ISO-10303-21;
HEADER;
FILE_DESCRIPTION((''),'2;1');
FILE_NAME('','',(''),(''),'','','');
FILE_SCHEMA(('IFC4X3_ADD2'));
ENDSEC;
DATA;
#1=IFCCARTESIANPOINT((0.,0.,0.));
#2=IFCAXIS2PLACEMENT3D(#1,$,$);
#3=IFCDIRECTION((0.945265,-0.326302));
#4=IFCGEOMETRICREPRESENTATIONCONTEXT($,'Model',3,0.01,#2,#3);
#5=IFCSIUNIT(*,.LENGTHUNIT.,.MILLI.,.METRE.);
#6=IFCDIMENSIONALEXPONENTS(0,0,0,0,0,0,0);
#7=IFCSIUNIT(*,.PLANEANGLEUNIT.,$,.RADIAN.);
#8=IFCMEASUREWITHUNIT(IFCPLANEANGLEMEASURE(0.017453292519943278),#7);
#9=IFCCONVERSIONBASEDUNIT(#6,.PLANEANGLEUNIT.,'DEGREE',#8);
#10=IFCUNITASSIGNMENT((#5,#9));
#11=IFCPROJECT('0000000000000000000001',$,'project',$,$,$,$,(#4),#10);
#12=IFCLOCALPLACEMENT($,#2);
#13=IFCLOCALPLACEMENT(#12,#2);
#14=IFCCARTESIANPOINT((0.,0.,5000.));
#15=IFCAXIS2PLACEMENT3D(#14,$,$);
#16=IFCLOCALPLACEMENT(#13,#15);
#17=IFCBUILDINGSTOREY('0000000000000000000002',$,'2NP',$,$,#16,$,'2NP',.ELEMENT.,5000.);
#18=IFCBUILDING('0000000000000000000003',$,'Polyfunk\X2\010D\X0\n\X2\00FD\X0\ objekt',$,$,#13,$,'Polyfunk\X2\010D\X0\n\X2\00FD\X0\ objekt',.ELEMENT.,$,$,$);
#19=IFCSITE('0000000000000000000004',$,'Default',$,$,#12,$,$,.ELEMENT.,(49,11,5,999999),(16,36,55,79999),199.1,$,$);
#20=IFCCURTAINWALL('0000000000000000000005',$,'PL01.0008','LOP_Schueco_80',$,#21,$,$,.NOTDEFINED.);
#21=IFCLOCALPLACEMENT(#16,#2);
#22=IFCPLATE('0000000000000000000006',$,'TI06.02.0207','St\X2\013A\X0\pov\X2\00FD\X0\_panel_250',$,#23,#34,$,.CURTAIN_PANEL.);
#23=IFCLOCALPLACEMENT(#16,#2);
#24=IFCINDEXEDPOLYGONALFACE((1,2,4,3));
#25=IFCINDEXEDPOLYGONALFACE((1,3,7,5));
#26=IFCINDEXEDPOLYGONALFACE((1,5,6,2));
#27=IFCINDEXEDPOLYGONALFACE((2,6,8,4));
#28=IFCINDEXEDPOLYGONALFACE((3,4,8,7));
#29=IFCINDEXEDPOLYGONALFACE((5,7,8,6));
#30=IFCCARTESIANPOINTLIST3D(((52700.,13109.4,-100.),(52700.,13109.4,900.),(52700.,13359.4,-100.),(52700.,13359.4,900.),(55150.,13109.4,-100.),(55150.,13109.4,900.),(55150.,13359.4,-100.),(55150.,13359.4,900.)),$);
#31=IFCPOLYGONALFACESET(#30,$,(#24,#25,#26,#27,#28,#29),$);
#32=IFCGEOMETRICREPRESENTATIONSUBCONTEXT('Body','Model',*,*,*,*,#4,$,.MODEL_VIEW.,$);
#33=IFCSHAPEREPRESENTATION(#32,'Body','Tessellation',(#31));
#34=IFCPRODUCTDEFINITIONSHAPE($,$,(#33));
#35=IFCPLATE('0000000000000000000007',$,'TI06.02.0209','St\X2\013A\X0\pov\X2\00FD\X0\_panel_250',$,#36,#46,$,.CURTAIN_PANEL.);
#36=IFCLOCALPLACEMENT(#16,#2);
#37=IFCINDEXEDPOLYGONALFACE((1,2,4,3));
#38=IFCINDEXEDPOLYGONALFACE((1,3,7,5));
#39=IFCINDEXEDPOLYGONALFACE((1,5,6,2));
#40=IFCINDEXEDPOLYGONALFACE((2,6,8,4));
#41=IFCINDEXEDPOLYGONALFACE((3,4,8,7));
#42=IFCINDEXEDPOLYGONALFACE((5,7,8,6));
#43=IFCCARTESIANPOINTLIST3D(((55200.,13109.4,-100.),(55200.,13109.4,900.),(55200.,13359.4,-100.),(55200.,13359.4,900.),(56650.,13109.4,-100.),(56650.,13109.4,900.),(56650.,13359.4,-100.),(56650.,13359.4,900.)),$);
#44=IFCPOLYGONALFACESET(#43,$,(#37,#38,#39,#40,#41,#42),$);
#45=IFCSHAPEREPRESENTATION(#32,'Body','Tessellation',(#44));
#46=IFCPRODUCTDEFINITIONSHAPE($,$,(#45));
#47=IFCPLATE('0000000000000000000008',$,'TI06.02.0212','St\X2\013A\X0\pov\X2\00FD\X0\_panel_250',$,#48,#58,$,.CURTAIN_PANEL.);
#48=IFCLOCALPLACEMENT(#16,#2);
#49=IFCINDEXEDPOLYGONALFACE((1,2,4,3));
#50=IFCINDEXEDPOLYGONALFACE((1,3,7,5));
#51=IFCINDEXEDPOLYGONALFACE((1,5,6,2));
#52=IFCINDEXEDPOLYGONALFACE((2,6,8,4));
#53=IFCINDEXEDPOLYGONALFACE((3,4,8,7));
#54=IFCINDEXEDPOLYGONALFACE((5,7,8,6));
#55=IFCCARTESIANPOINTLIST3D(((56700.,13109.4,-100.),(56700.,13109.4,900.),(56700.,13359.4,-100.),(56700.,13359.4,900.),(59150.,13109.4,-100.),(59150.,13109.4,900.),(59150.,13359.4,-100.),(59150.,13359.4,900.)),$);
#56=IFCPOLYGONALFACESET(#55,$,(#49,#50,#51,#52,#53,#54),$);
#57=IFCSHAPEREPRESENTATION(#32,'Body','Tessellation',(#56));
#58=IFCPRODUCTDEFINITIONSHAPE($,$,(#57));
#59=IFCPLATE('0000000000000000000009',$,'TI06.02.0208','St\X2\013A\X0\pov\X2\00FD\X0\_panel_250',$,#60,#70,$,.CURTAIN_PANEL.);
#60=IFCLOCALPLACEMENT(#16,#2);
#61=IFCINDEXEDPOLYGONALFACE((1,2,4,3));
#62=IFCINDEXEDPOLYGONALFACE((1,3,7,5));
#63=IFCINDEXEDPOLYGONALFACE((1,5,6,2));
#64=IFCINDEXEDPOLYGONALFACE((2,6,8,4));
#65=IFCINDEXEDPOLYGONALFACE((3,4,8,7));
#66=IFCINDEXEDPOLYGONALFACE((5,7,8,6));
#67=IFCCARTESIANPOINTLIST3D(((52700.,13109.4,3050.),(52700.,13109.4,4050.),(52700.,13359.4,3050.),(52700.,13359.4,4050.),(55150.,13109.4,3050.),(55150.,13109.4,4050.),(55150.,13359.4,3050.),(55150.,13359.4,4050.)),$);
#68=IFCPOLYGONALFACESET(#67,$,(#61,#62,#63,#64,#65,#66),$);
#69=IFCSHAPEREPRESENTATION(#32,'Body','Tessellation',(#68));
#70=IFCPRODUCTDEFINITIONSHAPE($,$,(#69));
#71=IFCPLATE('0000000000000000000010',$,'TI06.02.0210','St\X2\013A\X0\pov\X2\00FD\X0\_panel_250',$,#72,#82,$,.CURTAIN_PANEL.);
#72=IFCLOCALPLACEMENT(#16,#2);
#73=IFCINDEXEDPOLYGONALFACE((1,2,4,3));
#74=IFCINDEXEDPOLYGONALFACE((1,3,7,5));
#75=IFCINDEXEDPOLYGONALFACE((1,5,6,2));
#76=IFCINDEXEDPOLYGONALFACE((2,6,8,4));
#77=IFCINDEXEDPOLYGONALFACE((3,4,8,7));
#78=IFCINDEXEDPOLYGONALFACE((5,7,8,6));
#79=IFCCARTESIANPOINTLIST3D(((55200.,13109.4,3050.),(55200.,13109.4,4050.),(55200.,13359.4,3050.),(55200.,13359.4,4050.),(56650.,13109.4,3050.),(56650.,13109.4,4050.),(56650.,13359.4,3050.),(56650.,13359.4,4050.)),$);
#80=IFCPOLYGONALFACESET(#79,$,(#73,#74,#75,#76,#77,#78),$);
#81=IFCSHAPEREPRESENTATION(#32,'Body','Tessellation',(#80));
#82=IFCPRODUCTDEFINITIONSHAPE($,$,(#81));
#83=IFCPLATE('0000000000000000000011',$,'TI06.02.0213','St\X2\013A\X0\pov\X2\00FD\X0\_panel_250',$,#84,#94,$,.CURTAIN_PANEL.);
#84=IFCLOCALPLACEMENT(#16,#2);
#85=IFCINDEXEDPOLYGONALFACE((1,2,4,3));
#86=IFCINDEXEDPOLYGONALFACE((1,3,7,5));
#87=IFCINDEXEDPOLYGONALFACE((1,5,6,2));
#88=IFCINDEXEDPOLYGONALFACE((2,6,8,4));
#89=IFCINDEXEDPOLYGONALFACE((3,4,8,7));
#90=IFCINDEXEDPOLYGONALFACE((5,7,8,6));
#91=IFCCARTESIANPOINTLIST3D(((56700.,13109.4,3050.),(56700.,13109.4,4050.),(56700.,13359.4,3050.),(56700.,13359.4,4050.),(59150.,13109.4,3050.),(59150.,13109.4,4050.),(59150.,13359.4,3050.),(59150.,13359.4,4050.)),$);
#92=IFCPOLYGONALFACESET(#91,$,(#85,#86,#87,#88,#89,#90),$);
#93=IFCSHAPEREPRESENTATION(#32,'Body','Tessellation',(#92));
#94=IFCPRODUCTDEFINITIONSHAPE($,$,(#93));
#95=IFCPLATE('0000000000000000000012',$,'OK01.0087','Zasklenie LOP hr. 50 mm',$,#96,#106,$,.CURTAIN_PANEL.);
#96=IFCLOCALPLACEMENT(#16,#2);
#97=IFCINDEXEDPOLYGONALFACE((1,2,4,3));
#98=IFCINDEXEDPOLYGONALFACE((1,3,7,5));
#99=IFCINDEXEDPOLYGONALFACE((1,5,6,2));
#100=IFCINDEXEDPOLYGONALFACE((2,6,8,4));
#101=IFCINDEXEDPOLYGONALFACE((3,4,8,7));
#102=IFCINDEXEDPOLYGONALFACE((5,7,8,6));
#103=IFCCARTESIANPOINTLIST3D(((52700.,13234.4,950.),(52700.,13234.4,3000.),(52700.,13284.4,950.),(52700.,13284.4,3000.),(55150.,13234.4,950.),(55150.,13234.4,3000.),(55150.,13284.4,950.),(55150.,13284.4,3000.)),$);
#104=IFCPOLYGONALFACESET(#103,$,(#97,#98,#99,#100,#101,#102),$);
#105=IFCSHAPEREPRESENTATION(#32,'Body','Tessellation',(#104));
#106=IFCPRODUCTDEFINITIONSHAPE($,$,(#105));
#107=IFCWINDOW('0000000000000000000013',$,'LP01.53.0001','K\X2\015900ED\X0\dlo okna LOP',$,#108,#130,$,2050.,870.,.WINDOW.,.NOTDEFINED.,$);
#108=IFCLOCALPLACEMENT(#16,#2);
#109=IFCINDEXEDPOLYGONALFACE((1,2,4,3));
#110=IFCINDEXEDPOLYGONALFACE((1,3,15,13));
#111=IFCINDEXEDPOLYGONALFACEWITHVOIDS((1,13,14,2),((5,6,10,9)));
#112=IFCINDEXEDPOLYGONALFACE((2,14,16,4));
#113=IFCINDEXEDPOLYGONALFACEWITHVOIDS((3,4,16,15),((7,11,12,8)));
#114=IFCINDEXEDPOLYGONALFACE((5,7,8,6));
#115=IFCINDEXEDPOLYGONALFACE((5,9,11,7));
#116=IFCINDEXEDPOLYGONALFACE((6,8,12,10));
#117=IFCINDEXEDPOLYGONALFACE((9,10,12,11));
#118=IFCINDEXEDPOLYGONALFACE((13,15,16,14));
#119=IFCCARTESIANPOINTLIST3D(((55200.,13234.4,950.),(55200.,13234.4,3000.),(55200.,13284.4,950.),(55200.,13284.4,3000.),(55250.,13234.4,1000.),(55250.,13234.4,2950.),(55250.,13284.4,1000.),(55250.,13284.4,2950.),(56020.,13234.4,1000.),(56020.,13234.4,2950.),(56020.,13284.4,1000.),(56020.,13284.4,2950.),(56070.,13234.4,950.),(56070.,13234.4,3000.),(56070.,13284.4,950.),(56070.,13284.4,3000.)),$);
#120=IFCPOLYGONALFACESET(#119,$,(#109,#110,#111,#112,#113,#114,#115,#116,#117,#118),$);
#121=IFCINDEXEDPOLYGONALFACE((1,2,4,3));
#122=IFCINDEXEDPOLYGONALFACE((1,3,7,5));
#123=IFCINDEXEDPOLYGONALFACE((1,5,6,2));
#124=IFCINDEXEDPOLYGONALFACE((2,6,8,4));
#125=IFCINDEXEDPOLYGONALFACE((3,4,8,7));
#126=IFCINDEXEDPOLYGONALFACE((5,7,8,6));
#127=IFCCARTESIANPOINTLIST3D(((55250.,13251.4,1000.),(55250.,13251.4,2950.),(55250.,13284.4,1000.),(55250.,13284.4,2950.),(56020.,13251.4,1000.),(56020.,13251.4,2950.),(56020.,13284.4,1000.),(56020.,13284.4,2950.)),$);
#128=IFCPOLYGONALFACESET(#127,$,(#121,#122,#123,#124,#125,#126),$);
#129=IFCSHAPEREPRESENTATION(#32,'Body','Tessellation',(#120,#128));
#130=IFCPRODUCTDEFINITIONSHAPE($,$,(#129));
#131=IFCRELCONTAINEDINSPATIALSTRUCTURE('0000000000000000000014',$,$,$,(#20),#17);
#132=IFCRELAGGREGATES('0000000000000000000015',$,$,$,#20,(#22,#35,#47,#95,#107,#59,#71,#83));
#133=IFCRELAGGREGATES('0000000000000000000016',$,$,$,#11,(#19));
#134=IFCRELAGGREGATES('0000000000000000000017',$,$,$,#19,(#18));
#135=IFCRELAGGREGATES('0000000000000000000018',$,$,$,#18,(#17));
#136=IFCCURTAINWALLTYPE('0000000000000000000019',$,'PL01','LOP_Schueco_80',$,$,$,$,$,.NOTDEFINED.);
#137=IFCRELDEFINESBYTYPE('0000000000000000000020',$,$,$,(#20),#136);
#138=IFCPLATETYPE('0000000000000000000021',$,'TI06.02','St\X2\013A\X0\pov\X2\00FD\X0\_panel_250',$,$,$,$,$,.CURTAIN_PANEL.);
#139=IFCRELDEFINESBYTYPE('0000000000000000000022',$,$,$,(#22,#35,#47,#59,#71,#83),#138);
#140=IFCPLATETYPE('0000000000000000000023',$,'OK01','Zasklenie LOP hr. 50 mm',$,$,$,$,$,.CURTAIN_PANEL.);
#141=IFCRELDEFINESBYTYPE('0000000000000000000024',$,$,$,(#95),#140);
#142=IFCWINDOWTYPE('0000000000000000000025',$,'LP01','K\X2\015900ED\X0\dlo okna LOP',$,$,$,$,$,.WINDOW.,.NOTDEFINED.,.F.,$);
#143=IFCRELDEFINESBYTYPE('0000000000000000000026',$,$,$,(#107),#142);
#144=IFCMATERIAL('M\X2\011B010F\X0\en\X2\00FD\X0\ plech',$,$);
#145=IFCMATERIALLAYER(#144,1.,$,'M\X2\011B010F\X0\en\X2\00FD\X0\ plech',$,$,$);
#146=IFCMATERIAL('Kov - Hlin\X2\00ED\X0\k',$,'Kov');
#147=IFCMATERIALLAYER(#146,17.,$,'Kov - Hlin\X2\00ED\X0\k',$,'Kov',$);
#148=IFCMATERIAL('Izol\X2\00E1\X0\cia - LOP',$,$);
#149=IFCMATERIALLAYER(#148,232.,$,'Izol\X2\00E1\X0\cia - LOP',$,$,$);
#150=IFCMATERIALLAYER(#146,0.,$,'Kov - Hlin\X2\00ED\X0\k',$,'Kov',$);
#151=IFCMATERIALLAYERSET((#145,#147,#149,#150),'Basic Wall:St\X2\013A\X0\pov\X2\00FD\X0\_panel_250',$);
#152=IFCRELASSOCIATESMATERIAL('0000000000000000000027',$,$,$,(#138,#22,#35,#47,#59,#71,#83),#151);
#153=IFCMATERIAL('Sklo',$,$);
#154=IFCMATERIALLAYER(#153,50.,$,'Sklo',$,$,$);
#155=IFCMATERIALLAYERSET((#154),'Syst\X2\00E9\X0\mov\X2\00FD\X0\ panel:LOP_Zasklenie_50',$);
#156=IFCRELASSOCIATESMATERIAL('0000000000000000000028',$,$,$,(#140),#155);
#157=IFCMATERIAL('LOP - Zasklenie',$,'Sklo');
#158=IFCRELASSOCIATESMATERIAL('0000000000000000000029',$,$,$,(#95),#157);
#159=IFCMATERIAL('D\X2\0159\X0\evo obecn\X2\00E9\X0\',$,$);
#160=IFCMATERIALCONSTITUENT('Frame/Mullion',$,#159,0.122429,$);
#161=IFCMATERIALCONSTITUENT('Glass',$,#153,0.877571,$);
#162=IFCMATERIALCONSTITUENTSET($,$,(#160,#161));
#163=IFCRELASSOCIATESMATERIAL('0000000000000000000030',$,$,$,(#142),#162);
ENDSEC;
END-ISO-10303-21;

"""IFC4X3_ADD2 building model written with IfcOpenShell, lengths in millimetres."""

from ifc_helpers import new_model, entity, si_unit, converted_unit, direction, frame, frame_2d, origin, origin_2d_with_axis, place, context, subcontext, project, spatial, polyline, rectangle, outline, extrude, source, transform, mapped, material, layer, layer_set, layer_usage, constituent, constituent_set, type_object, type_shapes, element, aggregate, save


model = new_model("IFC4X3_ADD2")

# Units and contexts
model_context = context("Model", 3, precision=0.01, world=origin(), true_north=direction((0.945265, -0.326302)))
body_context = subcontext(model_context, "Body", "Model", "MODEL_VIEW")
ifc_project = project(units=[si_unit("LENGTHUNIT", "METRE", prefix="MILLI"), converted_unit("PLANEANGLEUNIT", "DEGREE", entity("IfcPlaneAngleMeasure", 0.017453292519943278), si_unit("PLANEANGLEUNIT", "RADIAN"), dimensions=[0, 0, 0, 0, 0, 0, 0])], contexts=[model_context])

# Site, building, storey
site_placement = place(None, origin())
site = spatial("IfcSite", under=ifc_project, at=site_placement, Name="Default", CompositionType="ELEMENT", RefLatitude=(49, 11, 5, 999999), RefLongitude=(16, 36, 55, 79999), RefElevation=199.1)
building_placement = place(site_placement, origin())
building = spatial("IfcBuilding", under=site, at=building_placement, Name="Polyfunkčný objekt", LongName="Polyfunkčný objekt", CompositionType="ELEMENT")
storey_placement = place(building_placement, frame((0.0, 0.0, 5000.0)))
storey = spatial("IfcBuildingStorey", under=building, at=storey_placement, Name="2NP", LongName="2NP", CompositionType="ELEMENT", Elevation=5000.0)

# Curtain wall, plates, window
curtain_wall_type = type_object("IfcCurtainWallType", Name="PL01", Description="LOP_Schueco_80", PredefinedType="NOTDEFINED")
curtain_wall_placement = place(storey_placement, frame((0.0, 0.0, -5000.0)))
curtain_wall = element("IfcCurtainWall", 1, at=curtain_wall_placement, inside=storey, type_object=curtain_wall_type, Name="PL01.0008", Description="LOP_Schueco_80", PredefinedType="NOTDEFINED")
ifc_material_1 = material(Name="Měďený plech")
ifc_layer_1 = layer(ifc_material_1, 1.0, Name="Měďený plech")
ifc_material_2 = material(Name="Kov - Hliník", Category="Kov")
ifc_layer_2 = layer(ifc_material_2, 17.0, Name="Kov - Hliník", Category="Kov")
ifc_material_3 = material(Name="Izolácia - LOP")
ifc_layer_3 = layer(ifc_material_3, 232.0, Name="Izolácia - LOP")
ifc_layer_4 = layer(ifc_material_2, 0.0, Name="Kov - Hliník", Category="Kov")
ifc_layer_set_1 = layer_set([ifc_layer_1, ifc_layer_2, ifc_layer_3, ifc_layer_4], Name="Basic Wall:Stĺpový_panel_250")
ifc_layer_usage_1 = layer_usage(ifc_layer_set_1, "AXIS2", "NEGATIVE", 125.0)
plate_type_1 = type_object("IfcPlateType", Name="TI06.02", Description="Stĺpový_panel_250", PredefinedType="CURTAIN_PANEL", material=ifc_layer_set_1)
plate_1_placement = place(storey_placement, frame((52700.0, 13234.4, -100.0)))
plate_1 = element("IfcPlate", 2, at=plate_1_placement, type_object=plate_type_1, material=ifc_layer_usage_1, Name="TI06.02.0207", Description="Stĺpový_panel_250", PredefinedType="CURTAIN_PANEL", context=body_context, shape_type="SweptSolid", body=[
    extrude(rectangle(XDim=250.0, YDim=2450.0, at=origin_2d_with_axis()), frame((1225.0, 0.0, 0.0), z_axis=(0.0, 0.0, 1.0), x_axis=(0.0, 1.0, 0.0)), (0.0, 0.0, 1.0), 1000.0),
])
ifc_layer_usage_2 = layer_usage(ifc_layer_set_1, "AXIS2", "NEGATIVE", 125.0)
plate_2_placement = place(storey_placement, frame((55200.0, 13234.4, -100.0)))
plate_2 = element("IfcPlate", 3, at=plate_2_placement, type_object=plate_type_1, material=ifc_layer_usage_2, Name="TI06.02.0209", Description="Stĺpový_panel_250", PredefinedType="CURTAIN_PANEL", context=body_context, shape_type="SweptSolid", body=[
    extrude(rectangle(XDim=250.0, YDim=1450.0, at=origin_2d_with_axis()), frame((725.0, 0.0, 0.0), z_axis=(0.0, 0.0, 1.0), x_axis=(0.0, 1.0, 0.0)), (0.0, 0.0, 1.0), 1000.0),
])
ifc_layer_usage_3 = layer_usage(ifc_layer_set_1, "AXIS2", "NEGATIVE", 125.0)
plate_3_placement = place(storey_placement, frame((56700.0, 13234.4, -100.0)))
plate_3 = element("IfcPlate", 4, at=plate_3_placement, type_object=plate_type_1, material=ifc_layer_usage_3, Name="TI06.02.0212", Description="Stĺpový_panel_250", PredefinedType="CURTAIN_PANEL", context=body_context, shape_type="SweptSolid", body=[
    extrude(rectangle(XDim=250.0, YDim=2450.0, at=frame_2d((0.0, 0.0), x_axis=(1.0, 0.0))), frame((1225.0, 0.0, 0.0), z_axis=(0.0, 0.0, 1.0), x_axis=(0.0, 1.0, 0.0)), (0.0, 0.0, 1.0), 1000.0),
])
ifc_layer_usage_4 = layer_usage(ifc_layer_set_1, "AXIS2", "NEGATIVE", 125.0)
plate_4_placement = place(storey_placement, frame((52700.0, 13234.4, 3050.0)))
plate_4 = element("IfcPlate", 5, at=plate_4_placement, type_object=plate_type_1, material=ifc_layer_usage_4, Name="TI06.02.0208", Description="Stĺpový_panel_250", PredefinedType="CURTAIN_PANEL", context=body_context, shape_type="SweptSolid", body=[
    extrude(rectangle(XDim=250.0, YDim=2450.0, at=origin_2d_with_axis()), frame((1225.0, 0.0, 0.0), z_axis=(0.0, 0.0, 1.0), x_axis=(0.0, 1.0, 0.0)), (0.0, 0.0, 1.0), 1000.0),
])
ifc_layer_usage_5 = layer_usage(ifc_layer_set_1, "AXIS2", "NEGATIVE", 125.0)
plate_5_placement = place(storey_placement, frame((55200.0, 13234.4, 3050.0)))
plate_5 = element("IfcPlate", 6, at=plate_5_placement, type_object=plate_type_1, material=ifc_layer_usage_5, Name="TI06.02.0210", Description="Stĺpový_panel_250", PredefinedType="CURTAIN_PANEL", context=body_context, shape_type="SweptSolid", body=[
    extrude(rectangle(XDim=250.0, YDim=1450.0, at=origin_2d_with_axis()), frame((725.0, 0.0, 0.0), z_axis=(0.0, 0.0, 1.0), x_axis=(0.0, 1.0, 0.0)), (0.0, 0.0, 1.0), 1000.0),
])
ifc_layer_usage_6 = layer_usage(ifc_layer_set_1, "AXIS2", "NEGATIVE", 125.0)
plate_6_placement = place(storey_placement, frame((56700.0, 13234.4, 3050.0)))
plate_6 = element("IfcPlate", 7, at=plate_6_placement, type_object=plate_type_1, material=ifc_layer_usage_6, Name="TI06.02.0213", Description="Stĺpový_panel_250", PredefinedType="CURTAIN_PANEL", context=body_context, shape_type="SweptSolid", body=[
    extrude(rectangle(XDim=250.0, YDim=2450.0, at=frame_2d((0.0, 0.0), x_axis=(1.0, 0.0))), frame((1225.0, 0.0, 0.0), z_axis=(0.0, 0.0, 1.0), x_axis=(0.0, 1.0, 0.0)), (0.0, 0.0, 1.0), 1000.0),
])
ifc_material_4 = material(Name="LOP - Zasklenie", Category="Sklo")
ifc_material_5 = material(Name="Sklo")
ifc_layer_5 = layer(ifc_material_5, 50.0, Name="Sklo")
ifc_layer_set_2 = layer_set([ifc_layer_5], Name="Systémový panel:LOP_Zasklenie_50")
plate_type_2 = type_object("IfcPlateType", Name="OK01", Description="Zasklenie LOP hr. 50 mm", PredefinedType="CURTAIN_PANEL", material=ifc_layer_set_2)
shared_shape_1 = source(origin(), body_context, "Body", "SweptSolid", [
    extrude(rectangle(XDim=50.0, YDim=2450.0, at=origin_2d_with_axis()), frame((0.0, 25.0, 0.0), z_axis=(0.0, 0.0, 1.0), x_axis=(0.0, 1.0, 0.0)), (0.0, 0.0, 1.0), 2050.0),
])
type_shapes(plate_type_2, [shared_shape_1])
plate_7_placement = place(curtain_wall_placement, frame((53925.0, 13234.4, 5950.0)))
plate_7 = element("IfcPlate", 8, at=plate_7_placement, type_object=plate_type_2, material=ifc_material_4, Name="OK01.0087", Description="Zasklenie LOP hr. 50 mm", PredefinedType="CURTAIN_PANEL", context=body_context, shape_type="MappedRepresentation", body=[
    mapped(shared_shape_1, transform((0.0, 0.0, 0.0), scale=1.0)),
])
ifc_material_6 = material(Name="Dřevo obecné")
ifc_constituent_1 = constituent(ifc_material_6, Name="Frame/Mullion", fraction=0.122429)
ifc_constituent_2 = constituent(ifc_material_5, Name="Glass", fraction=0.877571)
ifc_constituent_set = constituent_set(constituents=[ifc_constituent_1, ifc_constituent_2])
window_type = type_object("IfcWindowType", Name="LP01", Description="Křídlo okna LOP", ParameterTakesPrecedence=False, PartitioningType="NOTDEFINED", PredefinedType="WINDOW", material=ifc_constituent_set)
shared_shape_2 = source(origin(), body_context, "Body", "SweptSolid", [
    extrude(outline(polyline([(-1025.0, -435.0), (1025.0, -435.0), (1025.0, 435.0), (-1025.0, 435.0), (-1025.0, -435.0)]), holes=[polyline([(-975.0, -385.0), (-975.0, 385.0), (975.0, 385.0), (975.0, -385.0), (-975.0, -385.0)])]), frame((0.0, 0.0, 1025.0), z_axis=(0.0, 1.0, 0.0), x_axis=(0.0, 0.0, -1.0)), (0.0, 0.0, 1.0), 50.0),
    extrude(rectangle(XDim=33.0, YDim=770.0, at=origin_2d_with_axis()), frame((0.0, 33.5, 50.0), z_axis=(0.0, 0.0, 1.0), x_axis=(0.0, -1.0, 0.0)), (0.0, 0.0, 1.0), 1950.0),
])
type_shapes(window_type, [shared_shape_2])
window_placement = place(curtain_wall_placement, frame((55635.0, 13234.4, 5950.0)))
window = element("IfcWindow", 9, at=window_placement, type_object=window_type, Name="LP01.53.0001", Description="Křídlo okna LOP", OverallHeight=2050.0, OverallWidth=870.0, PartitioningType="NOTDEFINED", PredefinedType="WINDOW", context=body_context, shape_type="MappedRepresentation", body=[
    mapped(shared_shape_2, transform((0.0, 0.0, 0.0), scale=1.0)),
])
aggregate(curtain_wall, [plate_1, plate_2, plate_3, plate_7, window, plate_4, plate_5, plate_6])

save(model, "model.ifc")
